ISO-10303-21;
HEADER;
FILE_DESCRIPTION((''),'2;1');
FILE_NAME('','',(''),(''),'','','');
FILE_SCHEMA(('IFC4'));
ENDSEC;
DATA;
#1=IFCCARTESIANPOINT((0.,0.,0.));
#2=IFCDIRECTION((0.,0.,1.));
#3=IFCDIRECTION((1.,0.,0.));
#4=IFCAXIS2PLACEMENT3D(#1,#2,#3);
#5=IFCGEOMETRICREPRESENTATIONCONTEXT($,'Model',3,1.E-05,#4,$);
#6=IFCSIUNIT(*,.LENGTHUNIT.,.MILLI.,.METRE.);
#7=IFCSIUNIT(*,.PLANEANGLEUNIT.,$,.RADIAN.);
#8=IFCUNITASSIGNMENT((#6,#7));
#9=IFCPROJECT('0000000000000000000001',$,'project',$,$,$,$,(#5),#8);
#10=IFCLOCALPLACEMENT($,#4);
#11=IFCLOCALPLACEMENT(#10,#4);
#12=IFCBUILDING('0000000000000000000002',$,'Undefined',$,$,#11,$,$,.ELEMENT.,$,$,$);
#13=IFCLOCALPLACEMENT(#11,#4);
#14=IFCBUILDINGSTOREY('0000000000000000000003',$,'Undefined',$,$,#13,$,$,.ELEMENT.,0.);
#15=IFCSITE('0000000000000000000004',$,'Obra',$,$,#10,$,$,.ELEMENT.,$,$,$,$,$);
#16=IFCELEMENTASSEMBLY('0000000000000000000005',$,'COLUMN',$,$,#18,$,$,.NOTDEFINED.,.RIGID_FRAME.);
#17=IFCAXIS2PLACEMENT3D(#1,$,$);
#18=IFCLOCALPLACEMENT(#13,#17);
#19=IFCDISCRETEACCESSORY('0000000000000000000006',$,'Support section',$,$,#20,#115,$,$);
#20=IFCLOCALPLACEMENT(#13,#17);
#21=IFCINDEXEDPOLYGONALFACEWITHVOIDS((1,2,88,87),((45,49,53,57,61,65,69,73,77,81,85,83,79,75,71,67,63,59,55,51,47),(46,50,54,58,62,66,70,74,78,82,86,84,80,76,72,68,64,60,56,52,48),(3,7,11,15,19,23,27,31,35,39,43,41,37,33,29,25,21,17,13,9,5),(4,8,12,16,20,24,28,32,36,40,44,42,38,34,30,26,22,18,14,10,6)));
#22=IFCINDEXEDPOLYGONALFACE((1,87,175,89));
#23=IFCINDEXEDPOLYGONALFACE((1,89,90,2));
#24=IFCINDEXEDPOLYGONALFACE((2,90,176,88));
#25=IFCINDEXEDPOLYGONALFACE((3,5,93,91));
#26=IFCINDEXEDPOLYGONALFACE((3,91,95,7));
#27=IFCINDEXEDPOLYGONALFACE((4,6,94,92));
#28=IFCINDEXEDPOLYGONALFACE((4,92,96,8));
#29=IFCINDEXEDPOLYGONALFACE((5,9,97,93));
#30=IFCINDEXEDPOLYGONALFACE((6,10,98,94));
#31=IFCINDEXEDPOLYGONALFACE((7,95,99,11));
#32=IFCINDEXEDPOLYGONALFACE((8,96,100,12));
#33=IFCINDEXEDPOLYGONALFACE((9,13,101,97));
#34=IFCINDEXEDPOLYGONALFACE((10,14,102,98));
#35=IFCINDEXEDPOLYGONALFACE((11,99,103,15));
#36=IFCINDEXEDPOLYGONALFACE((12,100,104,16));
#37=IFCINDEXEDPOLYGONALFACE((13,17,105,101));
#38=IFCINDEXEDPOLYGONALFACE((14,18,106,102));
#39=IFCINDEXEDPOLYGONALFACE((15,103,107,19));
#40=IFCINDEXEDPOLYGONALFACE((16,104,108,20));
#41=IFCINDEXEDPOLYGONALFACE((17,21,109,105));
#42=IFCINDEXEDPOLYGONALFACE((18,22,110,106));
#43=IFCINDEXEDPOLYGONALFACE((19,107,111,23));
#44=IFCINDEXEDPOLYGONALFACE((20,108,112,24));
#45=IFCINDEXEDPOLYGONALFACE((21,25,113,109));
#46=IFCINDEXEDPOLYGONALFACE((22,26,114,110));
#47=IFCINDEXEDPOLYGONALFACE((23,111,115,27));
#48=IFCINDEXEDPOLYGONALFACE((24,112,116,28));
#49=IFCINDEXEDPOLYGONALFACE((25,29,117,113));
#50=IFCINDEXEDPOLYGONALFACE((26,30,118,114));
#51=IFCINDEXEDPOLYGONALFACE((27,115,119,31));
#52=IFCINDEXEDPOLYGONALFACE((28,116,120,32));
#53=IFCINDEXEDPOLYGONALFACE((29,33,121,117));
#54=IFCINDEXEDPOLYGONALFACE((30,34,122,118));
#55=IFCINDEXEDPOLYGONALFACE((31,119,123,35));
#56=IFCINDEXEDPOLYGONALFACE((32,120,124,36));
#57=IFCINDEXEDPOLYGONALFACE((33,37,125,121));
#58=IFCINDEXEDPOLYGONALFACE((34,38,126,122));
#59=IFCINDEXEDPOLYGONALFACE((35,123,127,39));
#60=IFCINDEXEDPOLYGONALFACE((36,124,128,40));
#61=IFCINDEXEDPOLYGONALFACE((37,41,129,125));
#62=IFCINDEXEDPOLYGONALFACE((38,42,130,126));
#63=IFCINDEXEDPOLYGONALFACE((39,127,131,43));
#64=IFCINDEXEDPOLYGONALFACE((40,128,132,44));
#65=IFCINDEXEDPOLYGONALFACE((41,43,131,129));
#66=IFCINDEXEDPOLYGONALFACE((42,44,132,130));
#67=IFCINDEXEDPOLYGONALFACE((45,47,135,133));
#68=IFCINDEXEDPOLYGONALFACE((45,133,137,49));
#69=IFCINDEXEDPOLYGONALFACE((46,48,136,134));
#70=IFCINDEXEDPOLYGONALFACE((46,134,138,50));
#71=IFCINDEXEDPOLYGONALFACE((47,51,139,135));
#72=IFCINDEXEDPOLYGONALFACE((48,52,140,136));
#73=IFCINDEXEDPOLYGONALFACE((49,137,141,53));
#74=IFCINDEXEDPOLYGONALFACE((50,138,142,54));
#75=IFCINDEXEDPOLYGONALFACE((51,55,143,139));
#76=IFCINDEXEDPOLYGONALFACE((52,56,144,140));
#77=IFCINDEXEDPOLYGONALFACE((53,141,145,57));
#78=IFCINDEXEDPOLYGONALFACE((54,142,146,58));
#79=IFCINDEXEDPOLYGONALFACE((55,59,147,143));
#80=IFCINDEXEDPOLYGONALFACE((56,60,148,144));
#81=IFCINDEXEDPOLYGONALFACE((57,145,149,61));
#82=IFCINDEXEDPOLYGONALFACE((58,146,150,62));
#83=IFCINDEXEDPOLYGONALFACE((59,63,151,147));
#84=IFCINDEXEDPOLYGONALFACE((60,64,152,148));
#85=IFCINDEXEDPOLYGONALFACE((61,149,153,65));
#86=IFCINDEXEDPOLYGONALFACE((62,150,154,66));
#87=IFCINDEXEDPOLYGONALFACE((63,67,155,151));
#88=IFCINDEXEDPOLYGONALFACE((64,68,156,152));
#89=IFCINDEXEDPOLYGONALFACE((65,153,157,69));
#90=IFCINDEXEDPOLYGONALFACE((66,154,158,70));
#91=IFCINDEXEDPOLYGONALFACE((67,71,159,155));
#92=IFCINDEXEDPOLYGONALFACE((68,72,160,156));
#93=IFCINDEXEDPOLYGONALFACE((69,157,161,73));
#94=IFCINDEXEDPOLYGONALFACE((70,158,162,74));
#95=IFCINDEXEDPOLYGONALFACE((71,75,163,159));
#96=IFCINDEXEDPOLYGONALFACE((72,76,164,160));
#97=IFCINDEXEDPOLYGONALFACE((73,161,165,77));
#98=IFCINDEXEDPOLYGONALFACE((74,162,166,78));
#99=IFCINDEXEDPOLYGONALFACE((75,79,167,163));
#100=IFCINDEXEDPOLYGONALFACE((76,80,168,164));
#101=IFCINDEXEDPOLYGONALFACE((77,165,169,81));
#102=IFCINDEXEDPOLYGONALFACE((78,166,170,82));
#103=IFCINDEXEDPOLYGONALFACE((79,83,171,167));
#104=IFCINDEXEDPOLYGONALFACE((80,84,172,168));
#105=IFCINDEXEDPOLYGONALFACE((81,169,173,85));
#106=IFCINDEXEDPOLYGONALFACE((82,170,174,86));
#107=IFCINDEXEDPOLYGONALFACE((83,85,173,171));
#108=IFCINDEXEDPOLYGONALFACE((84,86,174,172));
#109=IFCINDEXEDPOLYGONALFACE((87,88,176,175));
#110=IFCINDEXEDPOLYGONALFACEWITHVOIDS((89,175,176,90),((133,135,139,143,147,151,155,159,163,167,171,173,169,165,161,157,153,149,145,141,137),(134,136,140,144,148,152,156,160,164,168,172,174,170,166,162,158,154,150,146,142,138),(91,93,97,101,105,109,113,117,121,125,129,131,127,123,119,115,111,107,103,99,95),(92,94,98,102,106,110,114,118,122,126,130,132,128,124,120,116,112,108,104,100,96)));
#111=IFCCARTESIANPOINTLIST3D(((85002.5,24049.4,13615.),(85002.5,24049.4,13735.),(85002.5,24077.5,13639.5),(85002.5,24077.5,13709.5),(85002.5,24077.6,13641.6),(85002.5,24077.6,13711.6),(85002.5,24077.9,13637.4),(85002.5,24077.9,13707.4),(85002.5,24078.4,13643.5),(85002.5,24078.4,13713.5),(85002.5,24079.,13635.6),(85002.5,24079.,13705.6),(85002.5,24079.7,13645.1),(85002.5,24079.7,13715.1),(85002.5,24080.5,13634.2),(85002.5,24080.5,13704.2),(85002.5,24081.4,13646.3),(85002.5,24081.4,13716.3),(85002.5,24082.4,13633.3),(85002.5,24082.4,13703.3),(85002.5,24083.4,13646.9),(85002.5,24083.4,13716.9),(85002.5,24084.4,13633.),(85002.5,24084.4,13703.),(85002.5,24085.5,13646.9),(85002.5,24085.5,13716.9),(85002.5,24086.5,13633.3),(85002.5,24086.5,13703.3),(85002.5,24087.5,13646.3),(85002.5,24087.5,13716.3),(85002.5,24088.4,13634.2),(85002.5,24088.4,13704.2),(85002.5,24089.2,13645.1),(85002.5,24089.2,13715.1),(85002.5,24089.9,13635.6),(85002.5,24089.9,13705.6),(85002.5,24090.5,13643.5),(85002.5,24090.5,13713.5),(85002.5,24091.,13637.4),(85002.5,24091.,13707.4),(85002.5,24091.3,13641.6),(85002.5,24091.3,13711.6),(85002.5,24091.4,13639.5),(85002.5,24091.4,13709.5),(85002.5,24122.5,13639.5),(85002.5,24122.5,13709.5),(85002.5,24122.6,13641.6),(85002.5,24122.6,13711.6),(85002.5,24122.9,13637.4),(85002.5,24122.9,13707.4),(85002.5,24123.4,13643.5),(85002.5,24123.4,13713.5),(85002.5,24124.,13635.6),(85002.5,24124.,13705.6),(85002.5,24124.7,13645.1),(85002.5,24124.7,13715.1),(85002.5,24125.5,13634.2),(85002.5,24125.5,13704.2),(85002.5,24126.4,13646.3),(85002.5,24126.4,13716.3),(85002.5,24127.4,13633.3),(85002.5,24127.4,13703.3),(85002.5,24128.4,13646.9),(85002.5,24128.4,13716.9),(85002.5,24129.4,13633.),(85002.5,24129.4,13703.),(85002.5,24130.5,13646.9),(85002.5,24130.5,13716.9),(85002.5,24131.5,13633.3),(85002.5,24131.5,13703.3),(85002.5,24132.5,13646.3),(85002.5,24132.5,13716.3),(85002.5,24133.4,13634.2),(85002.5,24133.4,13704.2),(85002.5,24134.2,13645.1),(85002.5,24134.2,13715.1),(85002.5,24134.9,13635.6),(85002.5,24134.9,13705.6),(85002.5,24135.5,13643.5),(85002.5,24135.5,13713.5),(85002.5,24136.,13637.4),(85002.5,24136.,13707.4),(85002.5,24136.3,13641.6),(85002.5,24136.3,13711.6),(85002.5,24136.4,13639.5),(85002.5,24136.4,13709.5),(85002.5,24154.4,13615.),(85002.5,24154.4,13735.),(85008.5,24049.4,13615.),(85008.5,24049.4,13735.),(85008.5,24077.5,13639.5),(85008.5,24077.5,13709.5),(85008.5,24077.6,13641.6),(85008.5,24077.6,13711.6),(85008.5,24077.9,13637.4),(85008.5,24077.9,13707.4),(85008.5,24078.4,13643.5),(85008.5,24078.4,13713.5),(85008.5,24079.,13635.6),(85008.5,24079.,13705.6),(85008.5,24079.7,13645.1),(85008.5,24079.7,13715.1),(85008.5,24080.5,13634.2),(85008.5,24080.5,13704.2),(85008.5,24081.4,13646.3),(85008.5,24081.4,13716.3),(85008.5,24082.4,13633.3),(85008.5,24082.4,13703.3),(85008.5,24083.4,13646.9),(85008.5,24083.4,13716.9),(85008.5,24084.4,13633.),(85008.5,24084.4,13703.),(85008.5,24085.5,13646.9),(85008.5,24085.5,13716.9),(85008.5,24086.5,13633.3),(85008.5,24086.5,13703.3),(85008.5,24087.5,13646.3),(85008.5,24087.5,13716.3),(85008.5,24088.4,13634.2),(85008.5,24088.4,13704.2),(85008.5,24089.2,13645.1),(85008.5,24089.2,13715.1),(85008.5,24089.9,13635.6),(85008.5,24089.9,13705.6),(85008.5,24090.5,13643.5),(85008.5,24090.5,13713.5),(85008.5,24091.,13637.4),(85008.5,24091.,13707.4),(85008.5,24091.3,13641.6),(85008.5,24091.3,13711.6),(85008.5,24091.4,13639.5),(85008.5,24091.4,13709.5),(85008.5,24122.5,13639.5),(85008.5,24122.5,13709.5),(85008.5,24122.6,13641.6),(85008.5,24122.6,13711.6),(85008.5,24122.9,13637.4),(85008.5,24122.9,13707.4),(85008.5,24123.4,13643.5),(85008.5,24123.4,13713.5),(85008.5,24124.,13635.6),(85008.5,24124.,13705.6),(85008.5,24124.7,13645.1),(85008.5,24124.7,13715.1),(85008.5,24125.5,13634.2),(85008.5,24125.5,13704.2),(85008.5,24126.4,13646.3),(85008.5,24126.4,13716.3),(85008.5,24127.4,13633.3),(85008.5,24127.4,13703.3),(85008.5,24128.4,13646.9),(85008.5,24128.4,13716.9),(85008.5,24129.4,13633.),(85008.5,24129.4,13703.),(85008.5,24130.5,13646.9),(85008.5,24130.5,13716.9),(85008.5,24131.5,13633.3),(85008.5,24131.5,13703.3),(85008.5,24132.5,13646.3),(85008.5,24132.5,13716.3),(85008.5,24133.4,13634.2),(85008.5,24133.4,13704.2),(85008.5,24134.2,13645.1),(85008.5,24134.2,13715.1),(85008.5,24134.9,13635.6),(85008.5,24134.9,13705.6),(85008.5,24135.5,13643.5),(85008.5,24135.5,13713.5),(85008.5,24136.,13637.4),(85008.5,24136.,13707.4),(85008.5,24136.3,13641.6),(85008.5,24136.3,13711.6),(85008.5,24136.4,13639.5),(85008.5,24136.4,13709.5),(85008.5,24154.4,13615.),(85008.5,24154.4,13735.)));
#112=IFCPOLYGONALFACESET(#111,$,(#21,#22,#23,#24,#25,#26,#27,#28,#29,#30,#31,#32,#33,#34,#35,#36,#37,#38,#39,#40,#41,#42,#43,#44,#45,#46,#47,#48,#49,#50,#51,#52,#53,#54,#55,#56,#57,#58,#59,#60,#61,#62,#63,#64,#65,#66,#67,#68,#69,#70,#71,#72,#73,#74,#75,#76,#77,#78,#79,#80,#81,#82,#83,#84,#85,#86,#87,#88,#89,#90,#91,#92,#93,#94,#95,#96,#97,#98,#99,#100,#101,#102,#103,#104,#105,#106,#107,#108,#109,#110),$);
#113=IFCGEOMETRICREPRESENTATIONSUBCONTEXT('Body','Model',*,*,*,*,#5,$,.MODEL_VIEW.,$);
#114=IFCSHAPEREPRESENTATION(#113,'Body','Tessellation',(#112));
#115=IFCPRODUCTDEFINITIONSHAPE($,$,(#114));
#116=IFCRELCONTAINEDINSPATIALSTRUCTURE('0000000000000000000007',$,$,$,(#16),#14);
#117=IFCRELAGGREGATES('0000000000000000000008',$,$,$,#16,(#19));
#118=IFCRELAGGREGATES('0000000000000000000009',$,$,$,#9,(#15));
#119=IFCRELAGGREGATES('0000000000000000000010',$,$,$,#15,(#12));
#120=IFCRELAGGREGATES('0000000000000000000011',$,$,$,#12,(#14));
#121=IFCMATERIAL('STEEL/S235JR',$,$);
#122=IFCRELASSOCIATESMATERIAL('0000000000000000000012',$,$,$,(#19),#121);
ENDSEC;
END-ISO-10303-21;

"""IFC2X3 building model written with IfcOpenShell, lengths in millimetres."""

from ifc_helpers import new_model, si_unit, frame, origin_with_axes, origin_2d_with_axis, place, context, subcontext, project, spatial, rectangle, circle, extrude, source, transform, mapped, material, element, aggregate, save


model = new_model("IFC2X3")

# Units and contexts
model_context = context("Model", 3, precision=1e-05, world=origin_with_axes())
body_context = subcontext(model_context, "Body", "Model", "MODEL_VIEW")
ifc_project = project(units=[si_unit("LENGTHUNIT", "METRE", prefix="MILLI"), si_unit("PLANEANGLEUNIT", "RADIAN")], contexts=[model_context])

# Site, building, storey
site_placement = place(None, origin_with_axes())
site = spatial("IfcSite", under=ifc_project, at=site_placement, Name="Obra", CompositionType="ELEMENT")
building_placement = place(site_placement, origin_with_axes())
building = spatial("IfcBuilding", under=site, at=building_placement, Name="Undefined", CompositionType="ELEMENT")
storey_placement = place(building_placement, origin_with_axes())
storey = spatial("IfcBuildingStorey", under=building, at=storey_placement, Name="Undefined", CompositionType="ELEMENT", Elevation=0.0)

# Element assembly
assembly_1_placement = place(storey_placement, origin_with_axes())
assembly_1 = element("IfcElementAssembly", 1, at=assembly_1_placement, inside=storey, Name="COLUMN", AssemblyPlace="NOTDEFINED", PredefinedType="RIGID_FRAME")
ifc_material_1 = material(Name="STEEL/S235JR")

# Discrete accessory, opening
discrete_accessory_1_placement = place(assembly_1_placement, frame((85005.5, 24101.9, 13615.0), z_axis=(0.0, 0.0, 1.0), x_axis=(0.0, -1.0, 0.0)))
discrete_accessory_1 = element("IfcDiscreteAccessory", 2, at=discrete_accessory_1_placement, material=ifc_material_1, Name="Support section", context=body_context, shape_type="SweptSolid", body=[
    extrude(rectangle(XDim=6.0, YDim=105.0, at=origin_2d_with_axis()), frame((0.0, 0.0, 120.0), z_axis=(0.0, 0.0, -1.0), x_axis=(0.0, 1.0, 0.0)), (0.0, 0.0, 1.0), 120.0),
])
shared_shape_1 = source(origin_with_axes(), body_context, "Body", "SweptSolid", [
    extrude(circle(Radius=7.0, at=origin_2d_with_axis()), frame((0.0, -8.6, 0.0), z_axis=(0.0, 1.0, 0.0), x_axis=(1.0, 0.0, 0.0)), (0.0, 0.0, 1.0), 6.2),
])
opening_1_placement = place(assembly_1_placement, frame((85000.0, 24059.4, 13755.0), z_axis=(0.0, 1.0, 0.0), x_axis=(0.0, 0.0, -1.0)))
element("IfcOpeningElement", 3, at=opening_1_placement, cuts=discrete_accessory_1, ObjectType="Opening", context=body_context, shape_type="MappedRepresentation", body=[
    mapped(shared_shape_1, transform((45.0, 0.0, 25.0))),
    mapped(shared_shape_1, transform((45.0, 0.0, 70.0))),
    mapped(shared_shape_1, transform((115.0, 0.0, 25.0))),
    mapped(shared_shape_1, transform((115.0, 0.0, 70.0))),
])
aggregate(assembly_1, [discrete_accessory_1])

save(model, "model.ifc")
